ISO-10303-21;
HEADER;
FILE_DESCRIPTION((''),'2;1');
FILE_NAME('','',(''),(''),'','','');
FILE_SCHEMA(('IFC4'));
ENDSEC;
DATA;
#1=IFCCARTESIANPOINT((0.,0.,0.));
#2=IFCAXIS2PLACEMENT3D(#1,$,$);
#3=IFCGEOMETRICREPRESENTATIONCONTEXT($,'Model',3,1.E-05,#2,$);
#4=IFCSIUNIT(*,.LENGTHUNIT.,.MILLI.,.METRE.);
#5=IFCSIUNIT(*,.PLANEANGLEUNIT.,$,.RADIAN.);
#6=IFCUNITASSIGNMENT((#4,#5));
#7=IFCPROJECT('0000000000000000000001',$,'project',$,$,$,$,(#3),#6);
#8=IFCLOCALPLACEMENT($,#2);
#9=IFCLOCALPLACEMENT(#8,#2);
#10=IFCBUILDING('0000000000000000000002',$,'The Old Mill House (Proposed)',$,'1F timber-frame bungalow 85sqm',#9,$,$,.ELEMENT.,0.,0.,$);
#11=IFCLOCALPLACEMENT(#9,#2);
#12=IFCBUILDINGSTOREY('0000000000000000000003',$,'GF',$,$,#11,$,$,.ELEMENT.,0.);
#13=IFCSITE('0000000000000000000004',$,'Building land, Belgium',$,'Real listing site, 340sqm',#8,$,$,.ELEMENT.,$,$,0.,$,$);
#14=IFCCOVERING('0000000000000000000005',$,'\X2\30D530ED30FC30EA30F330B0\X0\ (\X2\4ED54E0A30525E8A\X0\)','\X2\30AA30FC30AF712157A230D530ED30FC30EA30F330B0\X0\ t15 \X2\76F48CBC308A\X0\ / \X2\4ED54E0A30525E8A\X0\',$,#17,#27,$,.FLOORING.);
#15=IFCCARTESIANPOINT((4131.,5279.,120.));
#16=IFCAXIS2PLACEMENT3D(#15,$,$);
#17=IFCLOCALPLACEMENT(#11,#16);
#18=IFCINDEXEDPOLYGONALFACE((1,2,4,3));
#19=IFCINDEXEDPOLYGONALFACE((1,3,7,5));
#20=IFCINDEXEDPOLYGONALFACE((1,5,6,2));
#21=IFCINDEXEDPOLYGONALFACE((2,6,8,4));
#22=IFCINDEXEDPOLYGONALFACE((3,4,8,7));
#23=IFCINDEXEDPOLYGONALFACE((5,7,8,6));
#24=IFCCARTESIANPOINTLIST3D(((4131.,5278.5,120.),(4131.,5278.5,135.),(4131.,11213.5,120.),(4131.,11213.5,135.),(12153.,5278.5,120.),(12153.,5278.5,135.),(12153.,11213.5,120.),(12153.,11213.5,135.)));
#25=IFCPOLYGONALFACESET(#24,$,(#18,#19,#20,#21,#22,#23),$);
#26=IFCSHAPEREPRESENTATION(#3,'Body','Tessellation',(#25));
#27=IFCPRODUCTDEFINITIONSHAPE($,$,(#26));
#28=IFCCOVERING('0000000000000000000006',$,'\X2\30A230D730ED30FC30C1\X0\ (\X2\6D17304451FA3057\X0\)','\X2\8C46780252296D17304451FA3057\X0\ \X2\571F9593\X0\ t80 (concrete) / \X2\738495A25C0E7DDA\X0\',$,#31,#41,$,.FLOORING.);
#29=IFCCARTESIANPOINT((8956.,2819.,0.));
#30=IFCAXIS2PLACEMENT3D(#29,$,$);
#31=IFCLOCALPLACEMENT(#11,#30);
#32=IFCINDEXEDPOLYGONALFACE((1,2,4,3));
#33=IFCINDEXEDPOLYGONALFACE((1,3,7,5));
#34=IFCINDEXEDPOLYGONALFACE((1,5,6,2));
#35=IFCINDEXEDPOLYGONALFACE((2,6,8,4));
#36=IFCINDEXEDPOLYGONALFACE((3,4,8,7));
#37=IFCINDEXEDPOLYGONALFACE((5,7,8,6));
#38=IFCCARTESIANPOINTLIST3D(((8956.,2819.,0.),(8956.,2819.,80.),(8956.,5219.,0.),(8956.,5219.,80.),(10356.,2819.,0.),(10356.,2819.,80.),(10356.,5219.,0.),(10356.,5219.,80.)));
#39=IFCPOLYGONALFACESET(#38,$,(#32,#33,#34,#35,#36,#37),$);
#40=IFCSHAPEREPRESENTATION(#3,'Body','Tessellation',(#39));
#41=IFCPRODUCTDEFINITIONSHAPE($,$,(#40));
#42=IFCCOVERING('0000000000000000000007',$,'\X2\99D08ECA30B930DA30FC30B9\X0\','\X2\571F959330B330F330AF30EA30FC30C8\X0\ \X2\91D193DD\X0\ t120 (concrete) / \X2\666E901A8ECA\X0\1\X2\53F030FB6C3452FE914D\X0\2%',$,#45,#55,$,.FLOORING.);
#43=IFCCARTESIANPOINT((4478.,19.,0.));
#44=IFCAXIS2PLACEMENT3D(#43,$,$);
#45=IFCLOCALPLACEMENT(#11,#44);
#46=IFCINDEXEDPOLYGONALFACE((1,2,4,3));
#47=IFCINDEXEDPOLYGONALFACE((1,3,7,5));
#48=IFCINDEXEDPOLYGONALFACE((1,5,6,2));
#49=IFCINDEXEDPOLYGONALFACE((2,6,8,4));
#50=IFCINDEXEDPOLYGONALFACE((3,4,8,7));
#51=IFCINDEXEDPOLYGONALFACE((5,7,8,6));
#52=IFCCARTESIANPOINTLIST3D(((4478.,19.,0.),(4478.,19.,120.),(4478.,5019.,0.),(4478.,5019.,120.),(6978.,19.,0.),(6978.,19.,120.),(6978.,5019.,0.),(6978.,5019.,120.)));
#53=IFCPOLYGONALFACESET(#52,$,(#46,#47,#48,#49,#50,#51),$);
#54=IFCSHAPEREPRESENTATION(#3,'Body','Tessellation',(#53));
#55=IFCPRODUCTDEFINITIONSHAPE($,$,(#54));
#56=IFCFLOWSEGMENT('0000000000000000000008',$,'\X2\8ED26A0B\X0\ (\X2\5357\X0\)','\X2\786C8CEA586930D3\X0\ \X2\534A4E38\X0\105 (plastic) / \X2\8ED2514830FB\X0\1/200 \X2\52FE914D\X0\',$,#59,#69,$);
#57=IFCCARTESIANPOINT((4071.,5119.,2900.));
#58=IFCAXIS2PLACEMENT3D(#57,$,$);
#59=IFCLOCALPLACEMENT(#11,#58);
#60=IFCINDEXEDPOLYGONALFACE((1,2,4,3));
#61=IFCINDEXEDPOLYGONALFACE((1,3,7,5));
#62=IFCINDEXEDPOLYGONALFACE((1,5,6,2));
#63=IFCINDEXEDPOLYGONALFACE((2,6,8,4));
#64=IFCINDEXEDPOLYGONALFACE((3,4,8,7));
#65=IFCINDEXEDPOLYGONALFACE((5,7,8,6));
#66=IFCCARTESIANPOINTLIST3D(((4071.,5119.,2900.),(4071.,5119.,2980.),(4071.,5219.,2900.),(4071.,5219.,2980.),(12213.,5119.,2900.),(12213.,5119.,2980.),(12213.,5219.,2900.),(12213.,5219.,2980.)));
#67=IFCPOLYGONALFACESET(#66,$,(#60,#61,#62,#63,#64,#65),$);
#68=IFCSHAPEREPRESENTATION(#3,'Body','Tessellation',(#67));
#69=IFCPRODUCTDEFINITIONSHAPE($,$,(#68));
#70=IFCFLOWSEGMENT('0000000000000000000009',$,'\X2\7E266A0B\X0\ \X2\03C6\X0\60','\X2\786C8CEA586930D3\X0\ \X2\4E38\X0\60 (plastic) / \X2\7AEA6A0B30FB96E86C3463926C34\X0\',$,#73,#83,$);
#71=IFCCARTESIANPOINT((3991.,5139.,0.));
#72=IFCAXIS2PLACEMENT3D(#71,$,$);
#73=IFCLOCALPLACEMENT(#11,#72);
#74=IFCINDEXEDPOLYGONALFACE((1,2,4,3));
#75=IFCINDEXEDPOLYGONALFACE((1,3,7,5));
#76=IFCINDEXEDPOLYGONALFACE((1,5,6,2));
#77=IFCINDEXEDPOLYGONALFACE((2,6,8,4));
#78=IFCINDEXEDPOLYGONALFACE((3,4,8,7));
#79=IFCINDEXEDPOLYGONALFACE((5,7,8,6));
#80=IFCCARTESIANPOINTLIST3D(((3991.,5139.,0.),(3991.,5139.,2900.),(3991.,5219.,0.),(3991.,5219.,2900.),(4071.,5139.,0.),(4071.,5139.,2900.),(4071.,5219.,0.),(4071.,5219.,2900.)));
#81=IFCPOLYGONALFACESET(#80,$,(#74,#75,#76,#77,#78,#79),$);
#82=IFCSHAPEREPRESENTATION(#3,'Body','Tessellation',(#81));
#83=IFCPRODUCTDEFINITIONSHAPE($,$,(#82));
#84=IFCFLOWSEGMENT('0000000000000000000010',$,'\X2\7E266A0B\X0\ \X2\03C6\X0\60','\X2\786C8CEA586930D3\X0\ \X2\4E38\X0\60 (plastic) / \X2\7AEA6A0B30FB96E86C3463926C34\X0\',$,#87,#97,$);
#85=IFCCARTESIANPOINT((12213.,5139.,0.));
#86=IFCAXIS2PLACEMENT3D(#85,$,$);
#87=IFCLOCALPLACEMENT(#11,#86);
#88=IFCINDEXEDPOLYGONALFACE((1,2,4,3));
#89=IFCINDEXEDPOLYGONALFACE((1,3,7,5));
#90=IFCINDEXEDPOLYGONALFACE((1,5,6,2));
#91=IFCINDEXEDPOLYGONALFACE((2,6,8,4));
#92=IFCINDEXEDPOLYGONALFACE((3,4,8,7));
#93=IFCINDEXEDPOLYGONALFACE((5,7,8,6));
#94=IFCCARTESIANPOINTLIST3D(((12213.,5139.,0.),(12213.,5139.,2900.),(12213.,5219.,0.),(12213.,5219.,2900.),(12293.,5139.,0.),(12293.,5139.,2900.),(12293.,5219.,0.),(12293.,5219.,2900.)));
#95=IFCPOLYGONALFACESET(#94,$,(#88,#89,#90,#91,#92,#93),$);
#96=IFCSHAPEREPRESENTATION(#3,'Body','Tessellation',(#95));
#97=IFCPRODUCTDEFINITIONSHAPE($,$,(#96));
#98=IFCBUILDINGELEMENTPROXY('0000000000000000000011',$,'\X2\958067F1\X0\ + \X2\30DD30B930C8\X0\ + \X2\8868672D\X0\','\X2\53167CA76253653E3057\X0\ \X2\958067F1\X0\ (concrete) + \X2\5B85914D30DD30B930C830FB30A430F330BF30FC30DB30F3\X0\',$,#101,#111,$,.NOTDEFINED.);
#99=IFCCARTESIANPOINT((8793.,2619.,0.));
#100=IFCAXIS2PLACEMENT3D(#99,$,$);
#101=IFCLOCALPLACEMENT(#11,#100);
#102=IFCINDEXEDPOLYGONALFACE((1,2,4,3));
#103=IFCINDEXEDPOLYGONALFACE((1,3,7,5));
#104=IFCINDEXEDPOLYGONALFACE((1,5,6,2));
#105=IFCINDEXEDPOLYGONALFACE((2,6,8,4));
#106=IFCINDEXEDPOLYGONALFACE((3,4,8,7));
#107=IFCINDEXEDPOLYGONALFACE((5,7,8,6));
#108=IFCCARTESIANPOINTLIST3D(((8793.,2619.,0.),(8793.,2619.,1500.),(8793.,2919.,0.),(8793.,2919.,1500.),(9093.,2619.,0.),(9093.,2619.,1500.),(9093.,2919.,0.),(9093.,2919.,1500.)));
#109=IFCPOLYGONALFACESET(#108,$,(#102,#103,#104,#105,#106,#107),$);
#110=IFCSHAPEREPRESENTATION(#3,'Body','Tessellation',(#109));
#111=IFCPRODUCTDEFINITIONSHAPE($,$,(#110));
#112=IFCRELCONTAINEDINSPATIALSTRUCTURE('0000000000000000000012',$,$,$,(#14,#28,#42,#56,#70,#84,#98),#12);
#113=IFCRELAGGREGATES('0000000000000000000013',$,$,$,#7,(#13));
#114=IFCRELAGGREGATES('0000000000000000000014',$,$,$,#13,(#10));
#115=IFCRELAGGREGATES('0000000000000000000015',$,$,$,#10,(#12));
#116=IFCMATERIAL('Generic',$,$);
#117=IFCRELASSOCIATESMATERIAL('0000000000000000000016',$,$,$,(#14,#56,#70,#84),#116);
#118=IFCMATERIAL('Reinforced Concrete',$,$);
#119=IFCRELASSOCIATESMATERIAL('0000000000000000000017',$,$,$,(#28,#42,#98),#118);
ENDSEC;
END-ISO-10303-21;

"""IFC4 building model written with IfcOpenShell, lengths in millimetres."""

from ifc_helpers import new_model, si_unit, frame, frame_2d, origin, place, context, project, spatial, rectangle, extrude, material, element, save


model = new_model("IFC4")

# Units and contexts
model_context = context("Model", 3, precision=1e-05, world=origin())
ifc_project = project(units=[si_unit("LENGTHUNIT", "METRE", prefix="MILLI"), si_unit("PLANEANGLEUNIT", "RADIAN")], contexts=[model_context])

# Site, building, storey
site_placement = place(None, origin())
site = spatial("IfcSite", under=ifc_project, at=site_placement, Name="Building land, Belgium", ObjectType="Real listing site, 340sqm", CompositionType="ELEMENT", RefElevation=0.0)
building_placement = place(site_placement, origin())
building = spatial("IfcBuilding", under=site, at=building_placement, Name="The Old Mill House (Proposed)", ObjectType="1F timber-frame bungalow 85sqm", CompositionType="ELEMENT", ElevationOfRefHeight=0.0, ElevationOfTerrain=0.0)
storey_placement = place(building_placement, origin())
storey = spatial("IfcBuildingStorey", under=building, at=storey_placement, Name="GF", CompositionType="ELEMENT", Elevation=0.0)

# Shared definitions
ifc_material_1 = material(Name="Reinforced Concrete")

# Coverings
ifc_material_2 = material(Name="Generic")
covering_1_placement = place(storey_placement, frame((4131.0, 5279.0, 120.0)))
element("IfcCovering", 1, at=covering_1_placement, inside=storey, material=ifc_material_2, Name="フローリング (仕上げ床)", Description="オーク無垢フローリング t15 直貼り / 仕上げ床", PredefinedType="FLOORING", context=model_context, shape_type="SweptSolid", body=[
    extrude(rectangle(XDim=8022.0, YDim=5935.0, at=frame_2d((4011.0, 2967.0))), frame((4131.0, 5279.0, 120.0)), (0.0, 0.0, 1.0), 15.0),
])
covering_2_placement = place(storey_placement, frame((8956.0, 2819.0, 0.0)))
element("IfcCovering", 2, at=covering_2_placement, inside=storey, material=ifc_material_1, Name="アプローチ (洗い出し)", Description="豆砂利洗い出し 土間 t80 (concrete) / 玄関導線", PredefinedType="FLOORING", context=model_context, shape_type="SweptSolid", body=[
    extrude(rectangle(XDim=1400.0, YDim=2400.0, at=frame_2d((700.0, 1200.0))), frame((8956.0, 2819.0, 0.0)), (0.0, 0.0, 1.0), 80.0),
])
covering_3_placement = place(storey_placement, frame((4478.0, 19.0, 0.0)))
element("IfcCovering", 3, at=covering_3_placement, inside=storey, material=ifc_material_1, Name="駐車スペース", Description="土間コンクリート 金鏝 t120 (concrete) / 普通車1台・水勾配2%", PredefinedType="FLOORING", context=model_context, shape_type="SweptSolid", body=[
    extrude(rectangle(XDim=2500.0, YDim=5000.0, at=frame_2d((1250.0, 2500.0))), frame((4478.0, 19.0, 0.0)), (0.0, 0.0, 1.0), 120.0),
])

# Flow segments
flow_segment_1_placement = place(storey_placement, frame((4071.0, 5119.0, 2900.0)))
element("IfcFlowSegment", 4, at=flow_segment_1_placement, inside=storey, material=ifc_material_2, Name="軒樋 (南)", Description="硬質塩ビ 半丸105 (plastic) / 軒先・1/200 勾配", context=model_context, shape_type="SweptSolid", body=[
    extrude(rectangle(XDim=8142.0, YDim=100.0, at=frame_2d((4071.0, 50.0))), frame((4071.0, 5119.0, 2900.0)), (0.0, 0.0, 1.0), 80.0),
])
flow_segment_2_placement = place(storey_placement, frame((3991.0, 5139.0, 0.0)))
element("IfcFlowSegment", 5, at=flow_segment_2_placement, inside=storey, material=ifc_material_2, Name="縦樋 φ60", Description="硬質塩ビ 丸60 (plastic) / 竪樋・雨水排水", context=model_context, shape_type="SweptSolid", body=[
    extrude(rectangle(XDim=80.0, YDim=80.0, at=frame_2d((40.0, 40.0))), frame((3991.0, 5139.0, 0.0)), (0.0, 0.0, 1.0), 2900.0),
])
flow_segment_3_placement = place(storey_placement, frame((12213.0, 5139.0, 0.0)))
element("IfcFlowSegment", 6, at=flow_segment_3_placement, inside=storey, material=ifc_material_2, Name="縦樋 φ60", Description="硬質塩ビ 丸60 (plastic) / 竪樋・雨水排水", context=model_context, shape_type="SweptSolid", body=[
    extrude(rectangle(XDim=80.0, YDim=80.0, at=frame_2d((40.0, 40.0))), frame((12213.0, 5139.0, 0.0)), (0.0, 0.0, 1.0), 2900.0),
])

# Building element proxy
proxy_placement = place(storey_placement, frame((8793.0, 2619.0, 0.0)))
element("IfcBuildingElementProxy", 7, at=proxy_placement, inside=storey, material=ifc_material_1, Name="門柱 + ポスト + 表札", Description="化粧打放し 門柱 (concrete) + 宅配ポスト・インターホン", PredefinedType="NOTDEFINED", context=model_context, shape_type="SweptSolid", body=[
    extrude(rectangle(XDim=300.0, YDim=300.0, at=frame_2d((150.0, 150.0))), frame((8793.0, 2619.0, 0.0)), (0.0, 0.0, 1.0), 1500.0),
])

save(model, "model.ifc")
